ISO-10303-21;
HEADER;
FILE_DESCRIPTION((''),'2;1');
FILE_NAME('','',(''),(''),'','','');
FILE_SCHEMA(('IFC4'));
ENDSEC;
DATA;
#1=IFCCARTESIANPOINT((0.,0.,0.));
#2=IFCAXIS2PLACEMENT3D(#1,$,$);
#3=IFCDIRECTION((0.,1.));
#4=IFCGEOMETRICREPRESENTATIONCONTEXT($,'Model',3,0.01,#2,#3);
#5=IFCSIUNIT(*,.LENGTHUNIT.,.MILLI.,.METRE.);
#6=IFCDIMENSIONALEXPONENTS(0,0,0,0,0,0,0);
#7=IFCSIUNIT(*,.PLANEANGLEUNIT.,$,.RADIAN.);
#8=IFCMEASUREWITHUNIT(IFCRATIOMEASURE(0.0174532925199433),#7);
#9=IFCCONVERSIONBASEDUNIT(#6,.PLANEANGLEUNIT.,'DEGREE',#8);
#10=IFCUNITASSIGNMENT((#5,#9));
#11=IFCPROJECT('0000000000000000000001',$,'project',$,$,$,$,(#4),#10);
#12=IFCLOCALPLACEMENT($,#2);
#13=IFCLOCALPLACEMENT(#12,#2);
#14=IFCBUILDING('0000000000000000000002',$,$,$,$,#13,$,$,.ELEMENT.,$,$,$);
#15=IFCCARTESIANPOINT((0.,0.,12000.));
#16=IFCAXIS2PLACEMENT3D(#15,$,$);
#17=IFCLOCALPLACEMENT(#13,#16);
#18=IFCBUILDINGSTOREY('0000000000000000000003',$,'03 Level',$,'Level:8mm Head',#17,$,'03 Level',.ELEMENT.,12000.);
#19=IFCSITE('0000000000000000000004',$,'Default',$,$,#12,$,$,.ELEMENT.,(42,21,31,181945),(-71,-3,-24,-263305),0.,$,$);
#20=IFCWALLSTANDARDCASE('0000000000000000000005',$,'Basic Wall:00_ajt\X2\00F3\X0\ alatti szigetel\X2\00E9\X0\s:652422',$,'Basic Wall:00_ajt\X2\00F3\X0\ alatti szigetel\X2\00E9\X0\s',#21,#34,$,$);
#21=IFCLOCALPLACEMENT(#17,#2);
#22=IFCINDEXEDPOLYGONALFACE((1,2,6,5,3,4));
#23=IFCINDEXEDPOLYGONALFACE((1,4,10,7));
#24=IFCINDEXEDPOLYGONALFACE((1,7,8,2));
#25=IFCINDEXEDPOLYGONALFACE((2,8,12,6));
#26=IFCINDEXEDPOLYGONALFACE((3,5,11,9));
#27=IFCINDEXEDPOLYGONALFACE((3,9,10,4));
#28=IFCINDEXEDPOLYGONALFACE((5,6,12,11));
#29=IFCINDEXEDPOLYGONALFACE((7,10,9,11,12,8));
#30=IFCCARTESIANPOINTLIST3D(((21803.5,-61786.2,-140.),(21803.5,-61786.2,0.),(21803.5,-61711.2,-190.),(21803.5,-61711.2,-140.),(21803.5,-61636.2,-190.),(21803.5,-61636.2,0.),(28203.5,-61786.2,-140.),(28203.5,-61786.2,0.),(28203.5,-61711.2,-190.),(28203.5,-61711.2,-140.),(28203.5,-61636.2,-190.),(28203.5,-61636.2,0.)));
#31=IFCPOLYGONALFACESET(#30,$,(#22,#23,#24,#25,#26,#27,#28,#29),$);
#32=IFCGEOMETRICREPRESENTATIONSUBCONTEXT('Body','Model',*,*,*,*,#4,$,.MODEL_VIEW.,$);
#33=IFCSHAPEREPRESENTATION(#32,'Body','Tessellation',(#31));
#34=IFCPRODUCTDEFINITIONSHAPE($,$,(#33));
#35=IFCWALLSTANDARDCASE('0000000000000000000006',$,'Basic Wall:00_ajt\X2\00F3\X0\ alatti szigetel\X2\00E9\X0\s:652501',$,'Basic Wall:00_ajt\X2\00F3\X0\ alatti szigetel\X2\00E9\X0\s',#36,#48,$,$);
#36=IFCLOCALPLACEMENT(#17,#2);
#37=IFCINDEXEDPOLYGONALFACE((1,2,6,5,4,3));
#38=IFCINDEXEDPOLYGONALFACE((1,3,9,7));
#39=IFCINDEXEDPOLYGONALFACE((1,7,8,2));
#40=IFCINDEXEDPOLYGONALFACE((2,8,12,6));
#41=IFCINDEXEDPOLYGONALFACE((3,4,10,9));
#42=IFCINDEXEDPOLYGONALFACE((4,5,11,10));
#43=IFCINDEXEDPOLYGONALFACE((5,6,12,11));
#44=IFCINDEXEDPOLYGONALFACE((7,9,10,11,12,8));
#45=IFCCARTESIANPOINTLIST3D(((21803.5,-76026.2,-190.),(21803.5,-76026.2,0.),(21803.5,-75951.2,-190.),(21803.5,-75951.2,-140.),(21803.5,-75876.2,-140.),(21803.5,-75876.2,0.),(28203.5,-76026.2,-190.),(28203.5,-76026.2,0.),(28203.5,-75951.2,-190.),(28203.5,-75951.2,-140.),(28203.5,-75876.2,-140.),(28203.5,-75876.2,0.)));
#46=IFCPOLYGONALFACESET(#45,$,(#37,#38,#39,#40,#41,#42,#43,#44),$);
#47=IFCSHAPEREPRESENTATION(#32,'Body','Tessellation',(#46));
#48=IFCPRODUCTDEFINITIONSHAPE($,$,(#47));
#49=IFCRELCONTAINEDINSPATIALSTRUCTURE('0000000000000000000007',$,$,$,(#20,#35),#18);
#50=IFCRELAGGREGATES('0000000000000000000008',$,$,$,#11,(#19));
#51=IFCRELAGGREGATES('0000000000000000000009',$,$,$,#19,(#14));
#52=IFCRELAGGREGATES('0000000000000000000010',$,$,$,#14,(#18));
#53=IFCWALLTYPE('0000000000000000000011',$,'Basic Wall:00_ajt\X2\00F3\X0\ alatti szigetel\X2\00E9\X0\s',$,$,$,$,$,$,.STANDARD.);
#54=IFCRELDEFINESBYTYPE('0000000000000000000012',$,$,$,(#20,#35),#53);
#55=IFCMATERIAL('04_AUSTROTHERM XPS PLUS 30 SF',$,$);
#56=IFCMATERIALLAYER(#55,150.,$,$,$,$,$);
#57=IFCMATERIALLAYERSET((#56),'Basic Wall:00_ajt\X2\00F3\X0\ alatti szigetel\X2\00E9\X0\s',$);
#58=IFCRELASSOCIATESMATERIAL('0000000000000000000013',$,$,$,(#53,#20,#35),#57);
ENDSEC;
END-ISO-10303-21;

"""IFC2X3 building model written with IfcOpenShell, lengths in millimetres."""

from ifc_helpers import new_model, entity, si_unit, converted_unit, direction, frame, frame_2d, origin, place, context, subcontext, project, spatial, polyline, rectangle, extrude, clip, bounded_halfspace, material, layer, layer_set, layer_usage, type_object, element, save


model = new_model("IFC2X3")

# Units and contexts
model_context = context("Model", 3, precision=0.01, world=origin(), true_north=direction((0.0, 1.0)))
body_context = subcontext(model_context, "Body", "Model", "MODEL_VIEW")
ifc_project = project(units=[si_unit("LENGTHUNIT", "METRE", prefix="MILLI"), converted_unit("PLANEANGLEUNIT", "DEGREE", entity("IfcRatioMeasure", 0.0174532925199433), si_unit("PLANEANGLEUNIT", "RADIAN"), dimensions=[0, 0, 0, 0, 0, 0, 0])], contexts=[model_context])

# Site, building, storey
site_placement = place(None, origin())
site = spatial("IfcSite", under=ifc_project, at=site_placement, Name="Default", CompositionType="ELEMENT", RefLatitude=(42, 21, 31, 181945), RefLongitude=(-71, -3, -24, -263305), RefElevation=0.0)
building_placement = place(site_placement, origin())
building = spatial("IfcBuilding", under=site, at=building_placement, CompositionType="ELEMENT")
storey_placement = place(building_placement, frame((0.0, 0.0, 12000.0)))
storey = spatial("IfcBuildingStorey", under=building, at=storey_placement, Name="03 Level", ObjectType="Level:8mm Head", LongName="03 Level", CompositionType="ELEMENT", Elevation=12000.0)

# Walls
ifc_material = material(Name="04_AUSTROTHERM XPS PLUS 30 SF")
ifc_layer = layer(ifc_material, 150.0)
ifc_layer_set = layer_set([ifc_layer], Name="Basic Wall:00_ajtó alatti szigetelés")
ifc_layer_usage_1 = layer_usage(ifc_layer_set, "AXIS2", "POSITIVE", -75.0)
wall_type = type_object("IfcWallType", Name="Basic Wall:00_ajtó alatti szigetelés", PredefinedType="STANDARD", material=ifc_layer_set)
wall_1_placement = place(storey_placement, frame((28203.5, -61711.2, -190.0), z_axis=(0.0, 0.0, 1.0), x_axis=(-1.0, 0.0, 0.0)))
element("IfcWallStandardCase", 1, at=wall_1_placement, inside=storey, type_object=wall_type, material=ifc_layer_usage_1, Name="Basic Wall:00_ajtó alatti szigetelés:652422", ObjectType="Basic Wall:00_ajtó alatti szigetelés", context=body_context, shape_type="Clipping", body=[
    clip(clip(extrude(rectangle(XDim=6400.0, YDim=150.0, at=frame_2d((3200.0, 0.0), x_axis=(-1.0, 0.0))), origin(), (0.0, 0.0, 1.0), 190.0), bounded_halfspace(frame((6400.0, 0.0, 50.0)), True, frame((6400.0, 0.0, 50.0)), polyline([(0.0, 0.0), (0.0, 75.0), (-6400.0, 75.0), (-6400.0, 0.0), (0.0, 0.0)]))), bounded_halfspace(frame((0.0, 0.0, 50.0), z_axis=(0.0, -1.0, 0.0), x_axis=(0.0, 0.0, 1.0)), True, frame((0.0, 0.0, 50.0), z_axis=(0.0, -1.0, 0.0), x_axis=(0.0, 0.0, 1.0)), polyline([(0.0, 0.0), (-50.0, 0.0), (-50.0, -6400.0), (0.0, -6400.0), (0.0, 0.0)]))),
])
ifc_layer_usage_2 = layer_usage(ifc_layer_set, "AXIS2", "NEGATIVE", 75.0)
wall_2_placement = place(storey_placement, frame((28203.5, -75951.2, -190.0), z_axis=(0.0, 0.0, 1.0), x_axis=(-1.0, 0.0, 0.0)))
element("IfcWallStandardCase", 2, at=wall_2_placement, inside=storey, type_object=wall_type, material=ifc_layer_usage_2, Name="Basic Wall:00_ajtó alatti szigetelés:652501", ObjectType="Basic Wall:00_ajtó alatti szigetelés", context=body_context, shape_type="Clipping", body=[
    clip(clip(extrude(rectangle(XDim=6400.0, YDim=150.0, at=frame_2d((3200.0, 0.0), x_axis=(-1.0, 0.0))), origin(), (0.0, 0.0, 1.0), 190.0), bounded_halfspace(frame((0.0, 0.0, 50.0)), True, frame((0.0, 0.0, 50.0)), polyline([(0.0, 0.0), (0.0, -75.0), (6400.0, -75.0), (6400.0, 0.0), (0.0, 0.0)]))), bounded_halfspace(frame((6400.0, 0.0, 50.0), z_axis=(0.0, 1.0, 0.0), x_axis=(0.0, 0.0, 1.0)), True, frame((6400.0, 0.0, 50.0), z_axis=(0.0, 1.0, 0.0), x_axis=(0.0, 0.0, 1.0)), polyline([(0.0, 0.0), (-50.0, 0.0), (-50.0, -6400.0), (0.0, -6400.0), (0.0, 0.0)]))),
])

save(model, "model.ifc")
